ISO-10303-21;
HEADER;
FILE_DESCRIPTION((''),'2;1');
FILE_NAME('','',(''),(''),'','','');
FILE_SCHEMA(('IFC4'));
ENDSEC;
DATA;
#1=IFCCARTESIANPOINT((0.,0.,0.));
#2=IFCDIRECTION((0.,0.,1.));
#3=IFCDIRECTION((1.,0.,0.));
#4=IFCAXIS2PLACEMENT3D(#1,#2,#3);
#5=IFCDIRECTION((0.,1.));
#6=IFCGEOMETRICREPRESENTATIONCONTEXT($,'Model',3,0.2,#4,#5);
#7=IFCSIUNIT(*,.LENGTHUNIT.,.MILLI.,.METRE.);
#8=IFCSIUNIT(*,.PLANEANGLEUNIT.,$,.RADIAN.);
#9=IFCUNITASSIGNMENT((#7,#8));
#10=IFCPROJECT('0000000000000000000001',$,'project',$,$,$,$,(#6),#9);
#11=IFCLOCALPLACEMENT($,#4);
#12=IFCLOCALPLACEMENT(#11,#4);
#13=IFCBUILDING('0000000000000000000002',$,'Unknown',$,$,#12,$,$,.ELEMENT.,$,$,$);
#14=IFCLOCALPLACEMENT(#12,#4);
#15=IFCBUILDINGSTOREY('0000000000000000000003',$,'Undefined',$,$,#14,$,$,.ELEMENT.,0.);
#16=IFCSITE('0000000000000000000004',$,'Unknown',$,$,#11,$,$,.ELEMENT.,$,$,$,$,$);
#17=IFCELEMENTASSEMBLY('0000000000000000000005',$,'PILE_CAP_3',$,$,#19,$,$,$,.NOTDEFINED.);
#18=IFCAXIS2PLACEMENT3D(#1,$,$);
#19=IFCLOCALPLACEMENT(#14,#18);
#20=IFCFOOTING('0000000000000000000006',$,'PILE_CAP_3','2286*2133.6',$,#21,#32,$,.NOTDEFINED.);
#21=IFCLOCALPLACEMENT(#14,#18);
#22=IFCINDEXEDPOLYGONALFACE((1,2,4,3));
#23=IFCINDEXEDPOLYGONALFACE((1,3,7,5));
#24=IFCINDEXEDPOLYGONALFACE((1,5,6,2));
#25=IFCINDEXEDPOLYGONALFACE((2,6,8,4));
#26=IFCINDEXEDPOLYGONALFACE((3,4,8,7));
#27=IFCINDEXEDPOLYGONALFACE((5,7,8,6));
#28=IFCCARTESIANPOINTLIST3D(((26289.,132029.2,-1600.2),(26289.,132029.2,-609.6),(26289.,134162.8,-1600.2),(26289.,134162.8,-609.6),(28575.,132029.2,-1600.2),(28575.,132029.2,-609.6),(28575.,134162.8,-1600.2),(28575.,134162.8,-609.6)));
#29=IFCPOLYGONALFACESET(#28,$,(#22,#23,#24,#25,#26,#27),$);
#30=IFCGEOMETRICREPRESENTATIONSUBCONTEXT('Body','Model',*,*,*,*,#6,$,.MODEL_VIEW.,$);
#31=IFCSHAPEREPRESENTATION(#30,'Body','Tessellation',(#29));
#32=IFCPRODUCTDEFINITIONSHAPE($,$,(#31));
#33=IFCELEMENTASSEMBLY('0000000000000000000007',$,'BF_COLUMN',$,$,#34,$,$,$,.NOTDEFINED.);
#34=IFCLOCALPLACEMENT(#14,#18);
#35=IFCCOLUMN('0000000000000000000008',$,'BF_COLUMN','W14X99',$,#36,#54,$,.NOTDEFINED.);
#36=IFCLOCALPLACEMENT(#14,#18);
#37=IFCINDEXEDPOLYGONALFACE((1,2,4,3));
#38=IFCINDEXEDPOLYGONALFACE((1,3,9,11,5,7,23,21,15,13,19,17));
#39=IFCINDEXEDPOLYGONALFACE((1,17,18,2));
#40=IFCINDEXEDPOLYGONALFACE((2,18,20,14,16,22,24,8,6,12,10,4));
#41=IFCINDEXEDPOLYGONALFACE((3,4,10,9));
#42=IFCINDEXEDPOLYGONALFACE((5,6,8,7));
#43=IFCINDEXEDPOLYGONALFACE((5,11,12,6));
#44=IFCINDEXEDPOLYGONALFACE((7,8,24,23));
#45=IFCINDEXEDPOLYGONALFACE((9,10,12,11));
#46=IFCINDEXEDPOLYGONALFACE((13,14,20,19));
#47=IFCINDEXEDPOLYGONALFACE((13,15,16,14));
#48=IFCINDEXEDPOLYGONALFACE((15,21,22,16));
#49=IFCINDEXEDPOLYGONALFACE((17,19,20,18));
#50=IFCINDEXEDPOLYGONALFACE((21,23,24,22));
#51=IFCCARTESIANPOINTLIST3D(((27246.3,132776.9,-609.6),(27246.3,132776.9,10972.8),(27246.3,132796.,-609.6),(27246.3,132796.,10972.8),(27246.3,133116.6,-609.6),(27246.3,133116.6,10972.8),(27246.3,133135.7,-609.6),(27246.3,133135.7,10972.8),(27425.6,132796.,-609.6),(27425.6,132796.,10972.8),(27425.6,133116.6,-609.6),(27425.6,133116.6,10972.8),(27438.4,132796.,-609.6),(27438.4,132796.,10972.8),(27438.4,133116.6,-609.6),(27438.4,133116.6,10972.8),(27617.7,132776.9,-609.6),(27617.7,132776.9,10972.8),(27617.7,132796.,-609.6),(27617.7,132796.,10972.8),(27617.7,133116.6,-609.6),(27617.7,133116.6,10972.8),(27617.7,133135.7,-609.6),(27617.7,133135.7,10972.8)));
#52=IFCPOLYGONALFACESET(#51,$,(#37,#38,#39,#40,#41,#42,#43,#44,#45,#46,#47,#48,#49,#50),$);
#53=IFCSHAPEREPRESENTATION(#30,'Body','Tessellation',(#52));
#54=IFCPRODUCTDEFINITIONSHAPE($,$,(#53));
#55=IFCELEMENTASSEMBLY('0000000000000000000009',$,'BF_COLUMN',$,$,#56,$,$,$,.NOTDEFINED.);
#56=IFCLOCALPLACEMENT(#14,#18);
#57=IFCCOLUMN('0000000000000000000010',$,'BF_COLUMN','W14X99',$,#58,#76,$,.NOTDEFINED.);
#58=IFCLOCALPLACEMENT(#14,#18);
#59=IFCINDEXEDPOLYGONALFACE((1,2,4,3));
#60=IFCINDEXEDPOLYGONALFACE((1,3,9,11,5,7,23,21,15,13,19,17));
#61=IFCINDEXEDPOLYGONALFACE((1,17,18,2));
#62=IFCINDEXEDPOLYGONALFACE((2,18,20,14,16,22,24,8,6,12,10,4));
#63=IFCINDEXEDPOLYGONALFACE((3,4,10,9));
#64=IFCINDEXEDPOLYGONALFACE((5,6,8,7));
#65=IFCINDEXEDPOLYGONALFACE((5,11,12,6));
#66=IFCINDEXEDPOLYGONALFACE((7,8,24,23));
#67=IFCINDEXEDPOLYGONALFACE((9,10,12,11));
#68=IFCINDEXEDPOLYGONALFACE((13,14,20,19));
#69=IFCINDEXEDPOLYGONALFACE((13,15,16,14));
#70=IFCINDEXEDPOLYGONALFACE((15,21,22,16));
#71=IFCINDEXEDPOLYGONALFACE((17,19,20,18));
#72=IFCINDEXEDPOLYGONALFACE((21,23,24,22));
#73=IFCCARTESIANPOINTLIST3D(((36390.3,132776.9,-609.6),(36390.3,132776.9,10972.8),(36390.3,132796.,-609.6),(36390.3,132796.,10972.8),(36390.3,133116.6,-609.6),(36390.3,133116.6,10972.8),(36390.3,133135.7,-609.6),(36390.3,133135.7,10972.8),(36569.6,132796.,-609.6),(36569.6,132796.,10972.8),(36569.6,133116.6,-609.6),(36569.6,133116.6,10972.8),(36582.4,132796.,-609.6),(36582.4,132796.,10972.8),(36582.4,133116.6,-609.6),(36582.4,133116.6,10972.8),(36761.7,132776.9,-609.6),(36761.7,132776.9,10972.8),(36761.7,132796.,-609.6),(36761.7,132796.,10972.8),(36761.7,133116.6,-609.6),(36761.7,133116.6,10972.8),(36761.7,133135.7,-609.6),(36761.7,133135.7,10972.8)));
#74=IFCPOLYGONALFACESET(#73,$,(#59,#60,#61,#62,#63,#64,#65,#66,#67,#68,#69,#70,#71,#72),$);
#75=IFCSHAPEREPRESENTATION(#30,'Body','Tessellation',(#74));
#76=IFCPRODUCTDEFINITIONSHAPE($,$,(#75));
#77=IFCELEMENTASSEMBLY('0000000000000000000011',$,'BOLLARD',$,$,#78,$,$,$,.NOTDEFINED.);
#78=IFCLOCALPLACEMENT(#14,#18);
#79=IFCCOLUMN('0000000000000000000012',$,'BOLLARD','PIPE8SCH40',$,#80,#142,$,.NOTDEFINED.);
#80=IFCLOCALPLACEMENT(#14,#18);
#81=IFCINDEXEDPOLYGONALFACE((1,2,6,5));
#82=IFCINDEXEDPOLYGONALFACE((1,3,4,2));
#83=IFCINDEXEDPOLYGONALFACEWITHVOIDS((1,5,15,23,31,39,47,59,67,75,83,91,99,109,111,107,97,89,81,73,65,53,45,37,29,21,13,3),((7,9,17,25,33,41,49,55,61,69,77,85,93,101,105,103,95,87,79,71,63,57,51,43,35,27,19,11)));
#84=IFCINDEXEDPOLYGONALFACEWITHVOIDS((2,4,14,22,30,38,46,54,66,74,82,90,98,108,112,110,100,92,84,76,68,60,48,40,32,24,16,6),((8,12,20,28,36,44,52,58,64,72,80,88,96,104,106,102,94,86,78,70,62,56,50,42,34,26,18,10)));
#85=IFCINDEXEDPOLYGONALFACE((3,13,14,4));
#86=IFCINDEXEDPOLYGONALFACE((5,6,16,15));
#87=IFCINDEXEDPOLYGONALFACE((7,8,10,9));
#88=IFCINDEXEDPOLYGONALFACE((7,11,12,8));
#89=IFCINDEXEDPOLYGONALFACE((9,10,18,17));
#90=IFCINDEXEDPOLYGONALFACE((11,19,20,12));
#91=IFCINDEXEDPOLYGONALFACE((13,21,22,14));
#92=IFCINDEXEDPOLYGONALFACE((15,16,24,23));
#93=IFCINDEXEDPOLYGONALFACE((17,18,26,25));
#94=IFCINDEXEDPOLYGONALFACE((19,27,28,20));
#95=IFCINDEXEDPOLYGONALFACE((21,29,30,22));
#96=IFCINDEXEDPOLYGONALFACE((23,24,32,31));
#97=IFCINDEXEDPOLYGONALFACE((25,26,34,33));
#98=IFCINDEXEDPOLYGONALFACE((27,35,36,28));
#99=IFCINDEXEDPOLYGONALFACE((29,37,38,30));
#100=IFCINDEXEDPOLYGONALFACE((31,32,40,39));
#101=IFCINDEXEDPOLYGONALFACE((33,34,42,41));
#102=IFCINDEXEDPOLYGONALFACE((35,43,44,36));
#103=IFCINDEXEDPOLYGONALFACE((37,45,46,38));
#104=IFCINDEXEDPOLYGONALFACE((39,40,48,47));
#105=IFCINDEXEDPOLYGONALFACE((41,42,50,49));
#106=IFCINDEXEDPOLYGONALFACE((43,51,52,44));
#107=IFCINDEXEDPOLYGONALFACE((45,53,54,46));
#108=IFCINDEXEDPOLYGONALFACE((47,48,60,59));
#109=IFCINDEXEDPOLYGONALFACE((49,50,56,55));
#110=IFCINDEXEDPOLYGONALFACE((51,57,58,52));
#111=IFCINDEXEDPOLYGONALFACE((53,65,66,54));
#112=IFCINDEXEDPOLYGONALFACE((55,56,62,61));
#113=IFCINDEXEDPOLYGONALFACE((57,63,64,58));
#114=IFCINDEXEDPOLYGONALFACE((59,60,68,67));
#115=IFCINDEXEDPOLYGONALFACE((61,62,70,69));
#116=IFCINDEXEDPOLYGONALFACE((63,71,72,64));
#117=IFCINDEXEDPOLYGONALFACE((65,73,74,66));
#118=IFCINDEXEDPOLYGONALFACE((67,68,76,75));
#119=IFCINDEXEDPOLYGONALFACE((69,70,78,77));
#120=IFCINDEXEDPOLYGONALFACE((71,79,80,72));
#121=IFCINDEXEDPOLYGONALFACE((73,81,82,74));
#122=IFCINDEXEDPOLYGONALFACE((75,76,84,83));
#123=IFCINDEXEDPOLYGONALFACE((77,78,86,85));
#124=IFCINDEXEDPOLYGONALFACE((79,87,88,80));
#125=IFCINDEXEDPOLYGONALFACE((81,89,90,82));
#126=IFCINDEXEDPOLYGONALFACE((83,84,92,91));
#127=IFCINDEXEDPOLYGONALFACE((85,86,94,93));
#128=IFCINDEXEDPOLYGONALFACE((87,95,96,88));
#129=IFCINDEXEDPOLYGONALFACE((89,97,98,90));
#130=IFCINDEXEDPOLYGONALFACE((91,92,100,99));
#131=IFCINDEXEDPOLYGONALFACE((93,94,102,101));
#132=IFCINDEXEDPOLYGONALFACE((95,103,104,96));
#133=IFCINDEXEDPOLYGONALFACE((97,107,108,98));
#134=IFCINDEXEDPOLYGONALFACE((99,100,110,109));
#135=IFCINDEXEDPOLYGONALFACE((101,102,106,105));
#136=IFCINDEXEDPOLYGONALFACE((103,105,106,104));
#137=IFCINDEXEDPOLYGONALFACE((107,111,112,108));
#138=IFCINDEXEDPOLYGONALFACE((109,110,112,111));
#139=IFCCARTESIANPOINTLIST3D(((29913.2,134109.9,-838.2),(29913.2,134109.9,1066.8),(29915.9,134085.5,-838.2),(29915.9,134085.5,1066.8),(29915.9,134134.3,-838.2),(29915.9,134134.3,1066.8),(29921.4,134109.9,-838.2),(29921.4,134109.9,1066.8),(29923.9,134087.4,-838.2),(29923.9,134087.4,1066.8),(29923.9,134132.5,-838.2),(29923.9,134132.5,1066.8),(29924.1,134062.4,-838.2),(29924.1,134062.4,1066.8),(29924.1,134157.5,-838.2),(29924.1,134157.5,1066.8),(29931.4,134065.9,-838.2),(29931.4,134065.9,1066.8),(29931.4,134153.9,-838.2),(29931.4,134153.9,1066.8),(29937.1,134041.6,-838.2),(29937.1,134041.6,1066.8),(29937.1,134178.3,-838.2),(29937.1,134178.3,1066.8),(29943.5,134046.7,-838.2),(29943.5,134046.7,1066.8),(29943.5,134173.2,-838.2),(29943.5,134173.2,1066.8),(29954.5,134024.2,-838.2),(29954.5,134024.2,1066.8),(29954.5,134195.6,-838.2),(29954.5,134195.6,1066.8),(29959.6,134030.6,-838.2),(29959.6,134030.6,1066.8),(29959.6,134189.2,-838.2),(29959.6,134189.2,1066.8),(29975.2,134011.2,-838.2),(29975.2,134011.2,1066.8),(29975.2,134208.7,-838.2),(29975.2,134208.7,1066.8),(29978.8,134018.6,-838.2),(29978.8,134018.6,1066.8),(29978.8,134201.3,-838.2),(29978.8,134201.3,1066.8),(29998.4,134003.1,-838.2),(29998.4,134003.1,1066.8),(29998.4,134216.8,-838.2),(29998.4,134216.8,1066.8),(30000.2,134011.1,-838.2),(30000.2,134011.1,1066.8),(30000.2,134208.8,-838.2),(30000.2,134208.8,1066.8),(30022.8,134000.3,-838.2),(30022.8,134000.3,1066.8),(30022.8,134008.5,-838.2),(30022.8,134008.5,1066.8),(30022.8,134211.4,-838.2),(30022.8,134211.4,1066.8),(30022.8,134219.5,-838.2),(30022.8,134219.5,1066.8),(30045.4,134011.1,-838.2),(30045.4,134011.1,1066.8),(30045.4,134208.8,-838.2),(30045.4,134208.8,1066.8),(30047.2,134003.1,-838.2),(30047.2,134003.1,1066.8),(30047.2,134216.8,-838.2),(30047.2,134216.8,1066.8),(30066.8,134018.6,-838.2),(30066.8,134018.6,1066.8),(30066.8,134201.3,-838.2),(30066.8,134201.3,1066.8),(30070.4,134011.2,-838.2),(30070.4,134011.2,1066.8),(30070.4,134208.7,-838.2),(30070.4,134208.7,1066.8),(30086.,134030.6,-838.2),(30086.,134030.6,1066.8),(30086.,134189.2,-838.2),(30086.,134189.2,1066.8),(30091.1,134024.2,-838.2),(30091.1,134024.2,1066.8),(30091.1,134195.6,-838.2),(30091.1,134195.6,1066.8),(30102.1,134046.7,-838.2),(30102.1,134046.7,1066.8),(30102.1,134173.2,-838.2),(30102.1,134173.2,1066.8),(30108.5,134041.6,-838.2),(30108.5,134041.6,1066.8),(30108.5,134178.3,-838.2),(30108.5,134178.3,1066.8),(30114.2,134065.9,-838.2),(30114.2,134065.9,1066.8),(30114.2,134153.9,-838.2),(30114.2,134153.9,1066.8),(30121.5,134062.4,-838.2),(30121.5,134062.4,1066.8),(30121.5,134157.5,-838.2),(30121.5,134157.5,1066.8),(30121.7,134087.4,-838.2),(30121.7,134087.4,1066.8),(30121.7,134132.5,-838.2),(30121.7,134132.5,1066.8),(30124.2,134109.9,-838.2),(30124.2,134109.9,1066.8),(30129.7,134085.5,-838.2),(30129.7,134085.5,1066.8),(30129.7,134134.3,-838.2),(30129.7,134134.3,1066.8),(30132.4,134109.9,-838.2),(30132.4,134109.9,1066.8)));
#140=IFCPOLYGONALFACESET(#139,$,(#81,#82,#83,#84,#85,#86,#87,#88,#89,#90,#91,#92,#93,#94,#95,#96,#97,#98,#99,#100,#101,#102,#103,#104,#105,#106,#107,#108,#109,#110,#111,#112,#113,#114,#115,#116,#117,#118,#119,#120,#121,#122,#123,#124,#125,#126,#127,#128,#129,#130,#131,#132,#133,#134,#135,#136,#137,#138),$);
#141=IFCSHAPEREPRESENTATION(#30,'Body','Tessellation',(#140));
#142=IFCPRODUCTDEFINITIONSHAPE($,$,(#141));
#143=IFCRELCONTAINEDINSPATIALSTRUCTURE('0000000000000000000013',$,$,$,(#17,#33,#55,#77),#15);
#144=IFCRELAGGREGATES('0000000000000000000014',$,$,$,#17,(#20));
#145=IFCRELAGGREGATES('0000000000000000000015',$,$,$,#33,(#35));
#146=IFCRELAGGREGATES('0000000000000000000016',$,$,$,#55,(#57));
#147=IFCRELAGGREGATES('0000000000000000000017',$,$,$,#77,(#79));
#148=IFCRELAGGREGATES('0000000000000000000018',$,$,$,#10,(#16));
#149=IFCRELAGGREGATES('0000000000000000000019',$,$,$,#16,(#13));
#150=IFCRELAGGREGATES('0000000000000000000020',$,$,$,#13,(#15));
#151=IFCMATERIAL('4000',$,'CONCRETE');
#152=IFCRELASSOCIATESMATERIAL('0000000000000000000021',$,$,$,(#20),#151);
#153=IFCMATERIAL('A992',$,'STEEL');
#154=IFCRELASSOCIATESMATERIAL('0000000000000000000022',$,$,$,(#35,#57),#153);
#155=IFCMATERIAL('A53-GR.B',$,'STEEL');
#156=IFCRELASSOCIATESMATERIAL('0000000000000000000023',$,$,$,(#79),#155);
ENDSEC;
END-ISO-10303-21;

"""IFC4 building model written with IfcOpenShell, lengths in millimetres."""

from ifc_helpers import new_model, si_unit, direction, frame, origin_with_axes, place, context, subcontext, project, spatial, line, indexed_curve, outline, extrude, material, element, aggregate, save


model = new_model("IFC4")

# Units and contexts
model_context = context("Model", 3, precision=0.2, world=origin_with_axes(), true_north=direction((0.0, 1.0)))
body_context = subcontext(model_context, "Body", "Model", "MODEL_VIEW")
ifc_project = project(units=[si_unit("LENGTHUNIT", "METRE", prefix="MILLI"), si_unit("PLANEANGLEUNIT", "RADIAN")], contexts=[model_context])

# Site, building, storey
site_placement = place(None, origin_with_axes())
site = spatial("IfcSite", under=ifc_project, at=site_placement, Name="Unknown", CompositionType="ELEMENT")
building_placement = place(site_placement, origin_with_axes())
building = spatial("IfcBuilding", under=site, at=building_placement, Name="Unknown", CompositionType="ELEMENT")
storey_placement = place(building_placement, origin_with_axes())
storey = spatial("IfcBuildingStorey", under=building, at=storey_placement, Name="Undefined", CompositionType="ELEMENT", Elevation=0.0)

# Element assembly, footing
assembly_1_placement = place(storey_placement, frame((27432.0, 133096.0, -1600.2), z_axis=(0.0, 1.0, 0.0), x_axis=(0.0, 0.0, 1.0)))
assembly_1 = element("IfcElementAssembly", 1, at=assembly_1_placement, inside=storey, Name="PILE_CAP_3", PredefinedType="NOTDEFINED")
ifc_material_1 = material(Name="4000", Category="CONCRETE")
footing_placement = place(assembly_1_placement, origin_with_axes())
footing = element("IfcFooting", 2, at=footing_placement, material=ifc_material_1, Name="PILE_CAP_3", Description="2286*2133.6", PredefinedType="NOTDEFINED", context=body_context, shape_type="SolidModel", body=[
    extrude(outline(indexed_curve([(-1066.8, -1143.0), (1066.8, -1143.0), (1066.8, 1143.0), (-1066.8, 1143.0)], segments=[line(1, 2, 3, 4, 1)])), frame((0.0, 0.0, 0.0), z_axis=(-1.0, 0.0, 0.0), x_axis=(0.0, 0.0, 1.0)), (0.0, 0.0, -1.0), 990.6),
])
aggregate(assembly_1, [footing])

# Element assemblies, columns
assembly_2_placement = place(storey_placement, frame((27432.0, 132956.3, -609.6), z_axis=(-1.0, 0.0, 0.0), x_axis=(0.0, 0.0, 1.0)))
assembly_2 = element("IfcElementAssembly", 3, at=assembly_2_placement, inside=storey, Name="BF_COLUMN", PredefinedType="NOTDEFINED")
ifc_material_2 = material(Name="A992", Category="STEEL")
column_1_placement = place(assembly_2_placement, origin_with_axes())
column_1 = element("IfcColumn", 4, at=column_1_placement, material=ifc_material_2, Name="BF_COLUMN", Description="W14X99", PredefinedType="NOTDEFINED", context=body_context, shape_type="SolidModel", body=[
    extrude(outline(indexed_curve([(-185.7, -179.4), (185.7, -179.4), (185.7, -160.3), (6.3, -160.3), (6.3, 160.3), (185.7, 160.3), (185.7, 179.4), (-185.7, 179.4), (-185.7, 160.3), (-6.3, 160.3), (-6.3, -160.3), (-185.7, -160.3)], segments=[line(1, 2, 3, 4, 5, 6, 7, 8, 9, 10, 11, 12, 1)])), frame((0.0, 0.0, 0.0), z_axis=(-1.0, 0.0, 0.0), x_axis=(0.0, 0.0, 1.0)), (0.0, 0.0, -1.0), 11582.4),
])
aggregate(assembly_2, [column_1])
assembly_3_placement = place(storey_placement, frame((36576.0, 132956.3, -609.6), z_axis=(-1.0, 0.0, 0.0), x_axis=(0.0, 0.0, 1.0)))
assembly_3 = element("IfcElementAssembly", 5, at=assembly_3_placement, inside=storey, Name="BF_COLUMN", PredefinedType="NOTDEFINED")
column_2_placement = place(assembly_3_placement, origin_with_axes())
column_2 = element("IfcColumn", 6, at=column_2_placement, material=ifc_material_2, Name="BF_COLUMN", Description="W14X99", PredefinedType="NOTDEFINED", context=body_context, shape_type="SolidModel", body=[
    extrude(outline(indexed_curve([(-185.7, -179.4), (185.7, -179.4), (185.7, -160.3), (6.3, -160.3), (6.3, 160.3), (185.7, 160.3), (185.7, 179.4), (-185.7, 179.4), (-185.7, 160.3), (-6.3, 160.3), (-6.3, -160.3), (-185.7, -160.3)], segments=[line(1, 2, 3, 4, 5, 6, 7, 8, 9, 10, 11, 12, 1)])), frame((0.0, 0.0, 0.0), z_axis=(-1.0, 0.0, 0.0), x_axis=(0.0, 0.0, 1.0)), (0.0, 0.0, -1.0), 11582.4),
])
aggregate(assembly_3, [column_2])
assembly_4_placement = place(storey_placement, frame((30022.8, 134109.9, -838.2), z_axis=(-1.0, 0.0, 0.0), x_axis=(0.0, 0.0, 1.0)))
assembly_4 = element("IfcElementAssembly", 7, at=assembly_4_placement, inside=storey, Name="BOLLARD", PredefinedType="NOTDEFINED")
ifc_material_3 = material(Name="A53-GR.B", Category="STEEL")
column_3_placement = place(assembly_4_placement, origin_with_axes())
column_3 = element("IfcColumn", 8, at=column_3_placement, material=ifc_material_3, Name="BOLLARD", Description="PIPE8SCH40", PredefinedType="NOTDEFINED", context=body_context, shape_type="SolidModel", body=[
    extrude(outline(indexed_curve([(109.6, 0.0), (106.9, 24.4), (98.7, 47.6), (85.7, 68.3), (68.3, 85.7), (47.6, 98.7), (24.4, 106.9), (0.0, 109.6), (-24.4, 106.9), (-47.6, 98.7), (-68.3, 85.7), (-85.7, 68.3), (-98.7, 47.6), (-106.9, 24.4), (-109.6, 0.0), (-106.9, -24.4), (-98.7, -47.6), (-85.7, -68.3), (-68.3, -85.7), (-47.6, -98.7), (-24.4, -106.9), (0.0, -109.6), (24.4, -106.9), (47.6, -98.7), (68.3, -85.7), (85.7, -68.3), (98.7, -47.6), (106.9, -24.4)], segments=[line(1, 2, 3, 4, 5, 6, 7, 8, 9, 10, 11, 12, 13, 14, 15, 16, 17, 18, 19, 20, 21, 22, 23, 24, 25, 26, 27, 28, 1)]), holes=[indexed_curve([(101.4, 0.0), (98.9, -22.6), (91.4, -44.0), (79.3, -63.2), (63.2, -79.3), (44.0, -91.4), (22.6, -98.9), (0.0, -101.4), (-22.6, -98.9), (-44.0, -91.4), (-63.2, -79.3), (-79.3, -63.2), (-91.4, -44.0), (-98.9, -22.6), (-101.4, 0.0), (-98.9, 22.6), (-91.4, 44.0), (-79.3, 63.2), (-63.2, 79.3), (-44.0, 91.4), (-22.6, 98.9), (0.0, 101.4), (22.6, 98.9), (44.0, 91.4), (63.2, 79.3), (79.3, 63.2), (91.4, 44.0), (98.9, 22.6)], segments=[line(1, 2, 3, 4, 5, 6, 7, 8, 9, 10, 11, 12, 13, 14, 15, 16, 17, 18, 19, 20, 21, 22, 23, 24, 25, 26, 27, 28, 1)])]), frame((0.0, 0.0, 0.0), z_axis=(-1.0, 0.0, 0.0), x_axis=(0.0, 0.0, 1.0)), (0.0, 0.0, -1.0), 1905.0),
])
aggregate(assembly_4, [column_3])

save(model, "model.ifc")
